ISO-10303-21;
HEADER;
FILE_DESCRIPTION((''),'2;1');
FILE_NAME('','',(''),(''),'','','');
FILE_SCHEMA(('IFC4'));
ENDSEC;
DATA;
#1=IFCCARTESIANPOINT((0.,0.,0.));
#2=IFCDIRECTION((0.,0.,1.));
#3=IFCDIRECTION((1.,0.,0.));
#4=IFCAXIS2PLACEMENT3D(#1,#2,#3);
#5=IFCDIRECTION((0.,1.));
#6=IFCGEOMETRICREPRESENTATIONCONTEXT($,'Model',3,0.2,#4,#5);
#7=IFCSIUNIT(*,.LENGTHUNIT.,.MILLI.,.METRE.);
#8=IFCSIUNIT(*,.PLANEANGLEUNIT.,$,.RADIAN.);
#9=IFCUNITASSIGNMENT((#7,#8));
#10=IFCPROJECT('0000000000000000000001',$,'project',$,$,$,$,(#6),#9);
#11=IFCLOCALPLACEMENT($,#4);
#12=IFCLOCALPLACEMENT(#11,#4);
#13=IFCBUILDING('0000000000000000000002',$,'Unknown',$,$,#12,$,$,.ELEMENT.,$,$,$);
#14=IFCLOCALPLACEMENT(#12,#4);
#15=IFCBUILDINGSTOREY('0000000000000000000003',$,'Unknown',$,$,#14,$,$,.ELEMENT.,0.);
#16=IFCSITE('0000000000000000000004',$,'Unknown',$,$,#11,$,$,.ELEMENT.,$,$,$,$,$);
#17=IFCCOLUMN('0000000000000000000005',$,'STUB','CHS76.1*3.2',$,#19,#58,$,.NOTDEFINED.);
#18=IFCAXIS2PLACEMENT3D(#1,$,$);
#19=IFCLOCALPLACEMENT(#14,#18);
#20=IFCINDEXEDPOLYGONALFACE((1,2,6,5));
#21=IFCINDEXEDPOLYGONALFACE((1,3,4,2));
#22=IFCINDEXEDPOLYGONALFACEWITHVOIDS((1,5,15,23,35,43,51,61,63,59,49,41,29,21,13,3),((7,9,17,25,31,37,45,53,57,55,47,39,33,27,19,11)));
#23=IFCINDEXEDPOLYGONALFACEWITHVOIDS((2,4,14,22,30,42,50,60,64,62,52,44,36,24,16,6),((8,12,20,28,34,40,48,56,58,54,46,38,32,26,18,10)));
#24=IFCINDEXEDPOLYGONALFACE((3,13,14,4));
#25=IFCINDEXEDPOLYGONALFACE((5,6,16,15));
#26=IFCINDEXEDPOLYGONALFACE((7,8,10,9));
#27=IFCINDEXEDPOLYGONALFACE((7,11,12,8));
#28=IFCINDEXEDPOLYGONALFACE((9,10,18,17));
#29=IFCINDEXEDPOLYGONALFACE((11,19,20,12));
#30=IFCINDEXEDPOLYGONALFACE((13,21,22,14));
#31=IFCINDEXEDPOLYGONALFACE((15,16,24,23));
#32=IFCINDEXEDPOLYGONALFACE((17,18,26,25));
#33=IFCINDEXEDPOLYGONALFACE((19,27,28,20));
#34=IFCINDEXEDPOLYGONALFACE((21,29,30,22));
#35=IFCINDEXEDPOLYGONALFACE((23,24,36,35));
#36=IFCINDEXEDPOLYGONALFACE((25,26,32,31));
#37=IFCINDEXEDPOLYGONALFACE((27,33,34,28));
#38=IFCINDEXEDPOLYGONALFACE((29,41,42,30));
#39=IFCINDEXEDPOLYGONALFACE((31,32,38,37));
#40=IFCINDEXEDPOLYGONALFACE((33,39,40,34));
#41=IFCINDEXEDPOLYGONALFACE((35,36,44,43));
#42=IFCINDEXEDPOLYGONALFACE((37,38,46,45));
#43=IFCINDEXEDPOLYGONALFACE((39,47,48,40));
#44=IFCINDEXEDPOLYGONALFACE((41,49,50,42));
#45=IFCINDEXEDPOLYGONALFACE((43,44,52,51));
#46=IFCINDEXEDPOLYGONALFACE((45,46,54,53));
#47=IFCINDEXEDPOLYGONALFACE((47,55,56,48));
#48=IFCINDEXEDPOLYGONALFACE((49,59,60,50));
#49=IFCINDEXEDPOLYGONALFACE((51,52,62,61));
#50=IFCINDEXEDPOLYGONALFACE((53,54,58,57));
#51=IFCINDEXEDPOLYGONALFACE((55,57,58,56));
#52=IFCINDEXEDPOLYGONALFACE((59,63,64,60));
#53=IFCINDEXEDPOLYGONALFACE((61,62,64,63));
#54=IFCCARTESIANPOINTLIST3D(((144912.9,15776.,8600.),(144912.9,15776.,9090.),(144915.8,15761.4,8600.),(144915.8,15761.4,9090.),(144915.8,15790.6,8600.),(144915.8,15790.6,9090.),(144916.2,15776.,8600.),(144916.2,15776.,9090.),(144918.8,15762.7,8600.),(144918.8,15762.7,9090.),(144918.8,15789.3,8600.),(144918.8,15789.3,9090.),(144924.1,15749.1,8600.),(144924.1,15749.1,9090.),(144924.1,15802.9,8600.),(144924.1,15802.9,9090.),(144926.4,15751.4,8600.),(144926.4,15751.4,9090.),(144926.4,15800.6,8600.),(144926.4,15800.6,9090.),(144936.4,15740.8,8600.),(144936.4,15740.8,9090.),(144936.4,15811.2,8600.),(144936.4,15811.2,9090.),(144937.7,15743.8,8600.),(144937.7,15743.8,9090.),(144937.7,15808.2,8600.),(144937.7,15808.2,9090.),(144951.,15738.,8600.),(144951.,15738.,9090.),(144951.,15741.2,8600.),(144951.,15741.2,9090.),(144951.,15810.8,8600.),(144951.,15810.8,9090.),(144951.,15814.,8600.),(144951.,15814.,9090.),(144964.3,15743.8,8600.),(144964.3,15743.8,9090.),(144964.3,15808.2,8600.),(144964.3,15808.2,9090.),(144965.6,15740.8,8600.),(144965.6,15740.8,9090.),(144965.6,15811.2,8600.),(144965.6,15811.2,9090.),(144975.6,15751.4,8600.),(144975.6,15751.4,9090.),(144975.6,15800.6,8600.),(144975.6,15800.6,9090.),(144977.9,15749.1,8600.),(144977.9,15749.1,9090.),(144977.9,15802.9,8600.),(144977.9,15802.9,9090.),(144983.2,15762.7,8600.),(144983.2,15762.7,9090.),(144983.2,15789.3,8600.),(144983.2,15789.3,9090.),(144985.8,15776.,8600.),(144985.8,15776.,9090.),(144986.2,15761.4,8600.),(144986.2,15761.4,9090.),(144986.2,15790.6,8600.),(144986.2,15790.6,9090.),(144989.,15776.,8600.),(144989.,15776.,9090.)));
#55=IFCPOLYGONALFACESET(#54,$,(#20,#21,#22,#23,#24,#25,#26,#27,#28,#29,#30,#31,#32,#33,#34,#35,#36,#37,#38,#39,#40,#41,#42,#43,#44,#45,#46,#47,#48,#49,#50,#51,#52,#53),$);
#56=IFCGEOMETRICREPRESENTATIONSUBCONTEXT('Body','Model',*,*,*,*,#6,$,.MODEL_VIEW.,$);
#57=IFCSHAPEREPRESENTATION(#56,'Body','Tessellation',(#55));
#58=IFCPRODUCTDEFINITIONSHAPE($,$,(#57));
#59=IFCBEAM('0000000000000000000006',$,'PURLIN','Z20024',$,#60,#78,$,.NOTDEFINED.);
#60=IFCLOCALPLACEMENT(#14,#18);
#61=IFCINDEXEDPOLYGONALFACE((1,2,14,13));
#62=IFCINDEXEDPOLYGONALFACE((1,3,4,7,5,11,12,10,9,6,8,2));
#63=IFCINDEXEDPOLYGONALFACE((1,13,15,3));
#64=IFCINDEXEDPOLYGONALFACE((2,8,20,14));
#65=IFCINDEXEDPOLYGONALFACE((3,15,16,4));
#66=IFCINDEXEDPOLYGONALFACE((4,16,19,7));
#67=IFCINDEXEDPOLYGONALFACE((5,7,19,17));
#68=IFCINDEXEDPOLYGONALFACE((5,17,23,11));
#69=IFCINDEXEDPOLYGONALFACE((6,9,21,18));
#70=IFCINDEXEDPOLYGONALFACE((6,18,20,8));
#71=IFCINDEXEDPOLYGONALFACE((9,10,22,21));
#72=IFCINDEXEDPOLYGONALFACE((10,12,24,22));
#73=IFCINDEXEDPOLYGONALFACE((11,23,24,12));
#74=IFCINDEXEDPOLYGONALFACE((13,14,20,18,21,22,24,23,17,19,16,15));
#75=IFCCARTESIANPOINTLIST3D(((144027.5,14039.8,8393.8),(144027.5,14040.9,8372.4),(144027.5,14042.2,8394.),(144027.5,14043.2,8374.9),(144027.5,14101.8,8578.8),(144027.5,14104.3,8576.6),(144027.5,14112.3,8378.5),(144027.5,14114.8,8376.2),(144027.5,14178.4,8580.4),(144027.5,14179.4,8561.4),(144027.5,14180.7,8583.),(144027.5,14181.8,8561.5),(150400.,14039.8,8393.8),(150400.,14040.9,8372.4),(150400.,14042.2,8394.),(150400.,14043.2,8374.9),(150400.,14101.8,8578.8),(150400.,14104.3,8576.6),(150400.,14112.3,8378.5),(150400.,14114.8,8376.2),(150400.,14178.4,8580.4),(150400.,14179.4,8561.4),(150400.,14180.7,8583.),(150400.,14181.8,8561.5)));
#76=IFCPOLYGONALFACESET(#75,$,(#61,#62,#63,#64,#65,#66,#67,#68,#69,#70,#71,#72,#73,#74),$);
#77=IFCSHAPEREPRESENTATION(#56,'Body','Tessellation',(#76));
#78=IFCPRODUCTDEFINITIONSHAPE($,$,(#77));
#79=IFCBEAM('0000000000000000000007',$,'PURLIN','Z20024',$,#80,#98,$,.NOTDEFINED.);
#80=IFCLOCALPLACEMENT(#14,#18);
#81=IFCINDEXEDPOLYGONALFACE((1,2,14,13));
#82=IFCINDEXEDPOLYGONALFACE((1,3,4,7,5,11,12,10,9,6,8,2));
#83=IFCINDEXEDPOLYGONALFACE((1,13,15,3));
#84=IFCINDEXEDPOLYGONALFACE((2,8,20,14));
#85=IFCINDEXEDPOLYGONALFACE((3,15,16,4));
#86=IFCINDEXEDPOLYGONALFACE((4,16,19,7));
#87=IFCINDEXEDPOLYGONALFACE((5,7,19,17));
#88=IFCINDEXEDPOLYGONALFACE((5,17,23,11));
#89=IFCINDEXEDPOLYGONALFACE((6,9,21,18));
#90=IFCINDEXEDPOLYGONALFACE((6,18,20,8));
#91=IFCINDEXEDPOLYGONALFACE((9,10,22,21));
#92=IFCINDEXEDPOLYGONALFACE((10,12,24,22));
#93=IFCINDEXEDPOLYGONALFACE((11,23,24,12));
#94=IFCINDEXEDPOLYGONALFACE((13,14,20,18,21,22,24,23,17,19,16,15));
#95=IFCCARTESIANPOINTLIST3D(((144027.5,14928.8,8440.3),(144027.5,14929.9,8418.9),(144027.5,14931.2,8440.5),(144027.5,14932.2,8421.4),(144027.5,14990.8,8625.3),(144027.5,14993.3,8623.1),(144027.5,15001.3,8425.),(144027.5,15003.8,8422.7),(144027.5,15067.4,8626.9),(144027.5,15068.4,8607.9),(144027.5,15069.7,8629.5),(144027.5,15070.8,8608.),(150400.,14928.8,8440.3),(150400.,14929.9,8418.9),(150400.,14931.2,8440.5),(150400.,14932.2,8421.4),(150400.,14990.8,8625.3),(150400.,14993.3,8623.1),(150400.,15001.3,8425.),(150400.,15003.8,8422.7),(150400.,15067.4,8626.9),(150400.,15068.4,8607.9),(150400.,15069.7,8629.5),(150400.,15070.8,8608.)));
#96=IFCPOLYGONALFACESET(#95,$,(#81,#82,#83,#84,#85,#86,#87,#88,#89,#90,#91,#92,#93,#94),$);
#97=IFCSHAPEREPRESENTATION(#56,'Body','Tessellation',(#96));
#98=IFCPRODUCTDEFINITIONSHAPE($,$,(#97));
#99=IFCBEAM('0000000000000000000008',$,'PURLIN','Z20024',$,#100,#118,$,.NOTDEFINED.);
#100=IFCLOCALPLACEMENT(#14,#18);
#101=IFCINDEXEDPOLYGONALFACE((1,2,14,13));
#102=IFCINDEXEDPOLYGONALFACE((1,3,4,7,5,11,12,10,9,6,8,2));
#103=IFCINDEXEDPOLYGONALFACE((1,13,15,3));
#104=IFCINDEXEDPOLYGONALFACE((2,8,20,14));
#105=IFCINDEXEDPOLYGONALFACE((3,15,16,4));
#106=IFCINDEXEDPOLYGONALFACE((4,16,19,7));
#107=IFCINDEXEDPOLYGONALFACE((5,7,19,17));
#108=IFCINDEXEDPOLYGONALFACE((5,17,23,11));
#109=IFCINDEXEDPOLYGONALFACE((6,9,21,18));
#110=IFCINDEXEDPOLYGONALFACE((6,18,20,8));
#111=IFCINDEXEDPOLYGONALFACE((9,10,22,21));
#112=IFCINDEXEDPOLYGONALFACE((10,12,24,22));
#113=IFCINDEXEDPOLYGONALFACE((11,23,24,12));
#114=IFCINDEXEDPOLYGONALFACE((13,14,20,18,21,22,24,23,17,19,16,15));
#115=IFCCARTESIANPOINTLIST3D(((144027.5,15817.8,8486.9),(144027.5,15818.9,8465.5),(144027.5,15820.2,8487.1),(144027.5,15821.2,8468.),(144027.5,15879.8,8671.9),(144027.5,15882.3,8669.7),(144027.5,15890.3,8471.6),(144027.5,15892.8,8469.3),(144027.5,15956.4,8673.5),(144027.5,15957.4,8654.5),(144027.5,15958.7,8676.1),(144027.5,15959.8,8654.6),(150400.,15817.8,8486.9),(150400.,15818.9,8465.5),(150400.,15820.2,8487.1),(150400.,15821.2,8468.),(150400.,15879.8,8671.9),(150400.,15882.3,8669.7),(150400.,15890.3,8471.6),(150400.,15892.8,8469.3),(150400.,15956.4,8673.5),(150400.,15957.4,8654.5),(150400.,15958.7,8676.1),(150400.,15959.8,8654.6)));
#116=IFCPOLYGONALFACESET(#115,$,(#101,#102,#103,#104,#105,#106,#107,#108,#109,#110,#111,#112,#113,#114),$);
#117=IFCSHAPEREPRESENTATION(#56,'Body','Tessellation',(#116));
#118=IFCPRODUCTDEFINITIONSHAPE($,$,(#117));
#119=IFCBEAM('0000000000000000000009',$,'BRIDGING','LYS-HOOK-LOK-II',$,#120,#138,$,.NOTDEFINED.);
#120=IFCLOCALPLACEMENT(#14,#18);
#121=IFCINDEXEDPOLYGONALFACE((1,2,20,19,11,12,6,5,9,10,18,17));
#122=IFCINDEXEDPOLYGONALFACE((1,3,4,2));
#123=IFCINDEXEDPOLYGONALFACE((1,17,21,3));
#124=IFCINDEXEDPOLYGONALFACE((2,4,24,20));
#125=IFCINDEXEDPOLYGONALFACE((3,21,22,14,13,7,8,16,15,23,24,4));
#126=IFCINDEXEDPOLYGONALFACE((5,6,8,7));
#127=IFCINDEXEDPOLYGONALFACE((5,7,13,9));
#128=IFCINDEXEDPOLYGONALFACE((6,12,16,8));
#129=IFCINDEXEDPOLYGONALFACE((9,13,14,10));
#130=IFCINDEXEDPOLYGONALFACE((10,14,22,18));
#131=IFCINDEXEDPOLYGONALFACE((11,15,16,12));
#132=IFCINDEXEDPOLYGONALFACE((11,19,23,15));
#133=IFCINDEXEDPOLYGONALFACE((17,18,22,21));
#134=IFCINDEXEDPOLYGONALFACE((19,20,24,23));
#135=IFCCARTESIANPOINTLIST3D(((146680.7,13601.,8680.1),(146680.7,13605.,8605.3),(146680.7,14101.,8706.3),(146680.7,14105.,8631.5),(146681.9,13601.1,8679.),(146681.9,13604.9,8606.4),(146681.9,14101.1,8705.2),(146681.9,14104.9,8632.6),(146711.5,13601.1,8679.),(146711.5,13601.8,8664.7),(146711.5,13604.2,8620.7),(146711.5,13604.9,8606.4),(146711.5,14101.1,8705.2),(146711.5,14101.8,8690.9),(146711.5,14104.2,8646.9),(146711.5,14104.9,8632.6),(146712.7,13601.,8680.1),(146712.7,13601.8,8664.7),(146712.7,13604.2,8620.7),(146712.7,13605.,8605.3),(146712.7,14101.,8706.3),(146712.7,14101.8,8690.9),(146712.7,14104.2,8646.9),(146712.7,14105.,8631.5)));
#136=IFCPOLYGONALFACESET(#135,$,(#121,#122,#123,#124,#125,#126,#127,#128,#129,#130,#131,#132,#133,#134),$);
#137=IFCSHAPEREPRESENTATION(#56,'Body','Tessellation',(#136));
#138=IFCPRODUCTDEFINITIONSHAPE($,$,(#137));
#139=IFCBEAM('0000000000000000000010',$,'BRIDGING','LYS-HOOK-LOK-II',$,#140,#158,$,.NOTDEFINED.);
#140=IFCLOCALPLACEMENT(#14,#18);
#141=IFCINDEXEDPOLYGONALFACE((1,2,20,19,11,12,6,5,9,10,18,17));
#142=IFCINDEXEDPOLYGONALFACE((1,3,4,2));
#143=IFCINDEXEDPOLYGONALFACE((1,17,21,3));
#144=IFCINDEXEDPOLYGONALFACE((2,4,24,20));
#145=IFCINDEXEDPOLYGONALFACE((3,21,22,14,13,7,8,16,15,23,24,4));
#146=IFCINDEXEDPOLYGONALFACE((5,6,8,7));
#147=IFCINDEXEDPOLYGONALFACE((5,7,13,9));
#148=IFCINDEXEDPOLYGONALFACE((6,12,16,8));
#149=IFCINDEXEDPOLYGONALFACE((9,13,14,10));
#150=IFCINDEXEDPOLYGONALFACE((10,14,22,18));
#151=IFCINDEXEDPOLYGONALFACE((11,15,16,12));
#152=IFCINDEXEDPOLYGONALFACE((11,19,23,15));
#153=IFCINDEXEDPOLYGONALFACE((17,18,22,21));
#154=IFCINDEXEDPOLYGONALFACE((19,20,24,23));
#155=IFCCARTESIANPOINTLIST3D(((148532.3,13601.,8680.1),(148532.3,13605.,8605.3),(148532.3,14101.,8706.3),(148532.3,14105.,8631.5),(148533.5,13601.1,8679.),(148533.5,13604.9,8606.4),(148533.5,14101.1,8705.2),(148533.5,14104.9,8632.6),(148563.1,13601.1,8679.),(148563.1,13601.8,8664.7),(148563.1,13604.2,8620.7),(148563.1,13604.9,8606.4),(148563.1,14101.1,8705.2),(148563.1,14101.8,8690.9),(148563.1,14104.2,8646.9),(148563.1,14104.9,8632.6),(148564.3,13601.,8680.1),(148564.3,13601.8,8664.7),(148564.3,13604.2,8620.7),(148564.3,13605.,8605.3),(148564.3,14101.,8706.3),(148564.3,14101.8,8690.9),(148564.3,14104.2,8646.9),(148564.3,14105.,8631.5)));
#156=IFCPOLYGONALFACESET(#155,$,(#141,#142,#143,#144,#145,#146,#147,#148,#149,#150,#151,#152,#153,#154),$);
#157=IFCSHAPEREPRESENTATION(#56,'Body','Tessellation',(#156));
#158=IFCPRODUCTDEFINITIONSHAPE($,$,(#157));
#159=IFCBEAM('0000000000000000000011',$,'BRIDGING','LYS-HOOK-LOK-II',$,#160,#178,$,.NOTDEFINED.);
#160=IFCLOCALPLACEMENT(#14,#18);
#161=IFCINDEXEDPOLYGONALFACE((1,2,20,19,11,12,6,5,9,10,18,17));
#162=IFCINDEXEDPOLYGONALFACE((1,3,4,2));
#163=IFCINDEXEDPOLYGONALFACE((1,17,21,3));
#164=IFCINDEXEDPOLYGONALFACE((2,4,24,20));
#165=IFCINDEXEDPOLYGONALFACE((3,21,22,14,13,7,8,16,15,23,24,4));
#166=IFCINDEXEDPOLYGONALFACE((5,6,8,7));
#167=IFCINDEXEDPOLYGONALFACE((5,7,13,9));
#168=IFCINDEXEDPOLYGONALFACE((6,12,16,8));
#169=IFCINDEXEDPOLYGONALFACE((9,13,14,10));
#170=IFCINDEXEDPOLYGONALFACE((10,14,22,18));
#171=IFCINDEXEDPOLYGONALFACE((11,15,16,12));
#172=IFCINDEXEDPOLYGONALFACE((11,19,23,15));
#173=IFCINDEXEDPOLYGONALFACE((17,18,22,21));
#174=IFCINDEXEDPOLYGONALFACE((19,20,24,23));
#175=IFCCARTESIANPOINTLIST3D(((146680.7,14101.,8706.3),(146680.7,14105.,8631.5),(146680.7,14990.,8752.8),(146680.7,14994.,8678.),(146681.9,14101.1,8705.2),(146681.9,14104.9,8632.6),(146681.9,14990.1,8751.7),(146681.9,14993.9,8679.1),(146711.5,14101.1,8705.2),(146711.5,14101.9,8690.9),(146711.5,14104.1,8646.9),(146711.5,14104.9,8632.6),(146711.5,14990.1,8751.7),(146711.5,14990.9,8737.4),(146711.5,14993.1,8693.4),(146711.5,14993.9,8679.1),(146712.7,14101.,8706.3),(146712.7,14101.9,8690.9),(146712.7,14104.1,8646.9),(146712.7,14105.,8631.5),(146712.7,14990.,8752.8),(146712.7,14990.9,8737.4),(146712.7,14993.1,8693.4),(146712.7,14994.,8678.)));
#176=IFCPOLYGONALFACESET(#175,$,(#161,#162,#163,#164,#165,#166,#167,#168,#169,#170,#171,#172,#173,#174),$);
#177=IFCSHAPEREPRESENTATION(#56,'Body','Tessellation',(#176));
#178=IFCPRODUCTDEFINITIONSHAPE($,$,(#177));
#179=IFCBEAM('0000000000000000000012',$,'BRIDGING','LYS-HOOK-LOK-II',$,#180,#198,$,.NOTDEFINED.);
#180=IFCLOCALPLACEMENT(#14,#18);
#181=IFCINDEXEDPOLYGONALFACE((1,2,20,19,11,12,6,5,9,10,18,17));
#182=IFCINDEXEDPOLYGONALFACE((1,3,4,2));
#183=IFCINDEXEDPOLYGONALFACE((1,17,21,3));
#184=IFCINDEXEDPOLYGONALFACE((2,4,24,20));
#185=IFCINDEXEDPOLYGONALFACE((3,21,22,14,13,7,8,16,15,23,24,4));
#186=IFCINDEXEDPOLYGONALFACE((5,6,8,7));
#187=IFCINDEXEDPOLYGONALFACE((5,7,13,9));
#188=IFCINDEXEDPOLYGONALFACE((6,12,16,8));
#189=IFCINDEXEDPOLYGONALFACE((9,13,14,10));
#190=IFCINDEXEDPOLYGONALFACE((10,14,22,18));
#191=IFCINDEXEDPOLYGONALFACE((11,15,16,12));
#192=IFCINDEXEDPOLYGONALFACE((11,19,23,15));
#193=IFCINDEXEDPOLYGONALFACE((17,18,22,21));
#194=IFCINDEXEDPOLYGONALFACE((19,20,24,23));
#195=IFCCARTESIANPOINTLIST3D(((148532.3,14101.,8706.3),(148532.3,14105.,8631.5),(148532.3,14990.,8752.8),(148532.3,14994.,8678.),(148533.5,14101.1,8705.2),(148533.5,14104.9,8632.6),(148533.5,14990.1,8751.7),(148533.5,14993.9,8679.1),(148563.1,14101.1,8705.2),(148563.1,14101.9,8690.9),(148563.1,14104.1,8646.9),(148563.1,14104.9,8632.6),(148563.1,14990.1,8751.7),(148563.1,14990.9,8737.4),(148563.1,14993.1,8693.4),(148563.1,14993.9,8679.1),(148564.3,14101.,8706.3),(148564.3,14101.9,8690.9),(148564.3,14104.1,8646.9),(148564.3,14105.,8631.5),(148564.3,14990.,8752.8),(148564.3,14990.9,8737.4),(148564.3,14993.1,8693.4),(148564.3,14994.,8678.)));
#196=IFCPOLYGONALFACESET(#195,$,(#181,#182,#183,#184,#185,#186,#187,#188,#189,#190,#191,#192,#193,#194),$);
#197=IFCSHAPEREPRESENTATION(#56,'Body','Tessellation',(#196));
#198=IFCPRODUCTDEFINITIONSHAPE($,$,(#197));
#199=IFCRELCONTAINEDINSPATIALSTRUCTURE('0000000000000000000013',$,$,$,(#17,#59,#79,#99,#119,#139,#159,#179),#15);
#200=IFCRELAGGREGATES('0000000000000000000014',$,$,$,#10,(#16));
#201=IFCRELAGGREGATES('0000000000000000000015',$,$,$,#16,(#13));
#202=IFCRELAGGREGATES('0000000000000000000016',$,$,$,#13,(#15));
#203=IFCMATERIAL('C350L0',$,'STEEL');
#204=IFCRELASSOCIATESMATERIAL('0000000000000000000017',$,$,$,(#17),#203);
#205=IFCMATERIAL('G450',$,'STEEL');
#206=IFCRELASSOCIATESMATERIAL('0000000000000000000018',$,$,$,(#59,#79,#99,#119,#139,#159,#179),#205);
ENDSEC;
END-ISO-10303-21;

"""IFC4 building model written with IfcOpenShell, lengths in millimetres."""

from ifc_helpers import new_model, si_unit, direction, frame, origin_with_axes, place, context, subcontext, project, spatial, line, indexed_curve, outline, extrude, material, element, save


model = new_model("IFC4")

# Units and contexts
model_context = context("Model", 3, precision=0.2, world=origin_with_axes(), true_north=direction((0.0, 1.0)))
body_context = subcontext(model_context, "Body", "Model", "MODEL_VIEW")
ifc_project = project(units=[si_unit("LENGTHUNIT", "METRE", prefix="MILLI"), si_unit("PLANEANGLEUNIT", "RADIAN")], contexts=[model_context])

# Site, building, storey
site_placement = place(None, origin_with_axes())
site = spatial("IfcSite", under=ifc_project, at=site_placement, Name="Unknown", CompositionType="ELEMENT")
building_placement = place(site_placement, origin_with_axes())
building = spatial("IfcBuilding", under=site, at=building_placement, Name="Unknown", CompositionType="ELEMENT")
storey_placement = place(building_placement, origin_with_axes())
storey = spatial("IfcBuildingStorey", under=building, at=storey_placement, Name="Unknown", CompositionType="ELEMENT", Elevation=0.0)

# Column
ifc_material_1 = material(Name="C350L0", Category="STEEL")
column_placement = place(storey_placement, frame((144951.0, 15776.0, 8600.0), z_axis=(-1.0, 0.0, 0.0), x_axis=(0.0, 0.0, 1.0)))
element("IfcColumn", 1, at=column_placement, inside=storey, material=ifc_material_1, Name="STUB", Description="CHS76.1*3.2", PredefinedType="NOTDEFINED", context=body_context, shape_type="SolidModel", body=[
    extrude(outline(indexed_curve([(38.0, 0.0), (35.2, 14.6), (26.9, 26.9), (14.6, 35.2), (0.0, 38.0), (-14.6, 35.2), (-26.9, 26.9), (-35.2, 14.6), (-38.0, 0.0), (-35.2, -14.6), (-26.9, -26.9), (-14.6, -35.2), (0.0, -38.0), (14.6, -35.2), (26.9, -26.9), (35.2, -14.6)], segments=[line(1, 2, 3, 4, 5, 6, 7, 8, 9, 10, 11, 12, 13, 14, 15, 16, 1)]), holes=[indexed_curve([(34.9, 0.0), (32.2, -13.3), (24.6, -24.6), (13.3, -32.2), (0.0, -34.9), (-13.3, -32.2), (-24.6, -24.6), (-32.2, -13.3), (-34.9, 0.0), (-32.2, 13.3), (-24.6, 24.6), (-13.3, 32.2), (0.0, 34.9), (13.3, 32.2), (24.6, 24.6), (32.2, 13.3)], segments=[line(1, 2, 3, 4, 5, 6, 7, 8, 9, 10, 11, 12, 13, 14, 15, 16, 1)])]), frame((0.0, 0.0, 0.0), z_axis=(-1.0, 0.0, 0.0), x_axis=(0.0, 0.0, 1.0)), (0.0, 0.0, -1.0), 490.0),
])

# Beams
ifc_material_2 = material(Name="G450", Category="STEEL")
for number, where, z_axis, x_axis, name in (
    (2, (144027.5, 14108.3, 8477.5), (0.0, -0.99863, -0.052336), (1.0, 0.0, 0.0), "PURLIN"),
    (3, (144027.5, 14997.3, 8524.0), (0.0, -0.99863, -0.052336), (1.0, 0.0, 0.0), "PURLIN"),
    (4, (144027.5, 15886.3, 8570.6), (0.0, -0.99863, -0.052336), (1.0, 0.0, 0.0), "PURLIN"),
):
    element("IfcBeam", number, at=place(storey_placement, frame(where, z_axis=z_axis, x_axis=x_axis)), inside=storey, material=ifc_material_2, Name=name, Description="Z20024", PredefinedType="NOTDEFINED", context=body_context, shape_type="SolidModel", body=[
        extrude(outline(indexed_curve([(72.8, -101.5), (72.8, -80.0), (70.4, -80.0), (70.4, -99.1), (1.2, -99.1), (1.2, 101.5), (-77.8, 101.5), (-77.8, 80.0), (-75.4, 80.0), (-75.4, 99.1), (-1.2, 99.1), (-1.2, -101.5)], segments=[line(1, 2, 3, 4, 5, 6, 7, 8, 9, 10, 11, 12, 1)])), frame((0.0, 0.0, 0.0), z_axis=(-1.0, 0.0, 0.0), x_axis=(0.0, 0.0, 1.0)), (0.0, 0.0, -1.0), 6372.5),
    ])
for number, where, z_axis, x_axis, name in (
    (5, (146696.7, 13603.0, 8642.7), (1.0, 0.0, 0.0), (0.0, 0.99863, 0.052328), "BRIDGING"),
    (6, (148548.3, 13603.0, 8642.7), (1.0, 0.0, 0.0), (0.0, 0.99863, 0.052328), "BRIDGING"),
):
    element("IfcBeam", number, at=place(storey_placement, frame(where, z_axis=z_axis, x_axis=x_axis)), inside=storey, material=ifc_material_2, Name=name, Description="LYS-HOOK-LOK-II", PredefinedType="NOTDEFINED", context=body_context, shape_type="SolidModel", body=[
        extrude(outline(indexed_curve([(16.0, -37.5), (16.0, -22.0), (14.8, -22.0), (14.8, -36.3), (-14.8, -36.3), (-14.8, 36.3), (14.8, 36.3), (14.8, 22.0), (16.0, 22.0), (16.0, 37.5), (-16.0, 37.5), (-16.0, -37.5)], segments=[line(1, 2, 3, 4, 5, 6, 7, 8, 9, 10, 11, 12, 1)])), frame((0.0, 0.0, 0.0), z_axis=(-1.0, 0.0, 0.0), x_axis=(0.0, 0.0, 1.0)), (0.0, 0.0, -1.0), 500.7),
    ])
for number, where, z_axis, x_axis, name in (
    (7, (146696.7, 14103.0, 8668.9), (1.0, 0.0, 0.0), (0.0, 0.998635, 0.052235), "BRIDGING"),
    (8, (148548.3, 14103.0, 8668.9), (1.0, 0.0, 0.0), (0.0, 0.998635, 0.052235), "BRIDGING"),
):
    element("IfcBeam", number, at=place(storey_placement, frame(where, z_axis=z_axis, x_axis=x_axis)), inside=storey, material=ifc_material_2, Name=name, Description="LYS-HOOK-LOK-II", PredefinedType="NOTDEFINED", context=body_context, shape_type="SolidModel", body=[
        extrude(outline(indexed_curve([(16.0, -37.5), (16.0, -22.0), (14.8, -22.0), (14.8, -36.3), (-14.8, -36.3), (-14.8, 36.3), (14.8, 36.3), (14.8, 22.0), (16.0, 22.0), (16.0, 37.5), (-16.0, 37.5), (-16.0, -37.5)], segments=[line(1, 2, 3, 4, 5, 6, 7, 8, 9, 10, 11, 12, 1)])), frame((0.0, 0.0, 0.0), z_axis=(-1.0, 0.0, 0.0), x_axis=(0.0, 0.0, 1.0)), (0.0, 0.0, -1.0), 890.2),
    ])

save(model, "model.ifc")
